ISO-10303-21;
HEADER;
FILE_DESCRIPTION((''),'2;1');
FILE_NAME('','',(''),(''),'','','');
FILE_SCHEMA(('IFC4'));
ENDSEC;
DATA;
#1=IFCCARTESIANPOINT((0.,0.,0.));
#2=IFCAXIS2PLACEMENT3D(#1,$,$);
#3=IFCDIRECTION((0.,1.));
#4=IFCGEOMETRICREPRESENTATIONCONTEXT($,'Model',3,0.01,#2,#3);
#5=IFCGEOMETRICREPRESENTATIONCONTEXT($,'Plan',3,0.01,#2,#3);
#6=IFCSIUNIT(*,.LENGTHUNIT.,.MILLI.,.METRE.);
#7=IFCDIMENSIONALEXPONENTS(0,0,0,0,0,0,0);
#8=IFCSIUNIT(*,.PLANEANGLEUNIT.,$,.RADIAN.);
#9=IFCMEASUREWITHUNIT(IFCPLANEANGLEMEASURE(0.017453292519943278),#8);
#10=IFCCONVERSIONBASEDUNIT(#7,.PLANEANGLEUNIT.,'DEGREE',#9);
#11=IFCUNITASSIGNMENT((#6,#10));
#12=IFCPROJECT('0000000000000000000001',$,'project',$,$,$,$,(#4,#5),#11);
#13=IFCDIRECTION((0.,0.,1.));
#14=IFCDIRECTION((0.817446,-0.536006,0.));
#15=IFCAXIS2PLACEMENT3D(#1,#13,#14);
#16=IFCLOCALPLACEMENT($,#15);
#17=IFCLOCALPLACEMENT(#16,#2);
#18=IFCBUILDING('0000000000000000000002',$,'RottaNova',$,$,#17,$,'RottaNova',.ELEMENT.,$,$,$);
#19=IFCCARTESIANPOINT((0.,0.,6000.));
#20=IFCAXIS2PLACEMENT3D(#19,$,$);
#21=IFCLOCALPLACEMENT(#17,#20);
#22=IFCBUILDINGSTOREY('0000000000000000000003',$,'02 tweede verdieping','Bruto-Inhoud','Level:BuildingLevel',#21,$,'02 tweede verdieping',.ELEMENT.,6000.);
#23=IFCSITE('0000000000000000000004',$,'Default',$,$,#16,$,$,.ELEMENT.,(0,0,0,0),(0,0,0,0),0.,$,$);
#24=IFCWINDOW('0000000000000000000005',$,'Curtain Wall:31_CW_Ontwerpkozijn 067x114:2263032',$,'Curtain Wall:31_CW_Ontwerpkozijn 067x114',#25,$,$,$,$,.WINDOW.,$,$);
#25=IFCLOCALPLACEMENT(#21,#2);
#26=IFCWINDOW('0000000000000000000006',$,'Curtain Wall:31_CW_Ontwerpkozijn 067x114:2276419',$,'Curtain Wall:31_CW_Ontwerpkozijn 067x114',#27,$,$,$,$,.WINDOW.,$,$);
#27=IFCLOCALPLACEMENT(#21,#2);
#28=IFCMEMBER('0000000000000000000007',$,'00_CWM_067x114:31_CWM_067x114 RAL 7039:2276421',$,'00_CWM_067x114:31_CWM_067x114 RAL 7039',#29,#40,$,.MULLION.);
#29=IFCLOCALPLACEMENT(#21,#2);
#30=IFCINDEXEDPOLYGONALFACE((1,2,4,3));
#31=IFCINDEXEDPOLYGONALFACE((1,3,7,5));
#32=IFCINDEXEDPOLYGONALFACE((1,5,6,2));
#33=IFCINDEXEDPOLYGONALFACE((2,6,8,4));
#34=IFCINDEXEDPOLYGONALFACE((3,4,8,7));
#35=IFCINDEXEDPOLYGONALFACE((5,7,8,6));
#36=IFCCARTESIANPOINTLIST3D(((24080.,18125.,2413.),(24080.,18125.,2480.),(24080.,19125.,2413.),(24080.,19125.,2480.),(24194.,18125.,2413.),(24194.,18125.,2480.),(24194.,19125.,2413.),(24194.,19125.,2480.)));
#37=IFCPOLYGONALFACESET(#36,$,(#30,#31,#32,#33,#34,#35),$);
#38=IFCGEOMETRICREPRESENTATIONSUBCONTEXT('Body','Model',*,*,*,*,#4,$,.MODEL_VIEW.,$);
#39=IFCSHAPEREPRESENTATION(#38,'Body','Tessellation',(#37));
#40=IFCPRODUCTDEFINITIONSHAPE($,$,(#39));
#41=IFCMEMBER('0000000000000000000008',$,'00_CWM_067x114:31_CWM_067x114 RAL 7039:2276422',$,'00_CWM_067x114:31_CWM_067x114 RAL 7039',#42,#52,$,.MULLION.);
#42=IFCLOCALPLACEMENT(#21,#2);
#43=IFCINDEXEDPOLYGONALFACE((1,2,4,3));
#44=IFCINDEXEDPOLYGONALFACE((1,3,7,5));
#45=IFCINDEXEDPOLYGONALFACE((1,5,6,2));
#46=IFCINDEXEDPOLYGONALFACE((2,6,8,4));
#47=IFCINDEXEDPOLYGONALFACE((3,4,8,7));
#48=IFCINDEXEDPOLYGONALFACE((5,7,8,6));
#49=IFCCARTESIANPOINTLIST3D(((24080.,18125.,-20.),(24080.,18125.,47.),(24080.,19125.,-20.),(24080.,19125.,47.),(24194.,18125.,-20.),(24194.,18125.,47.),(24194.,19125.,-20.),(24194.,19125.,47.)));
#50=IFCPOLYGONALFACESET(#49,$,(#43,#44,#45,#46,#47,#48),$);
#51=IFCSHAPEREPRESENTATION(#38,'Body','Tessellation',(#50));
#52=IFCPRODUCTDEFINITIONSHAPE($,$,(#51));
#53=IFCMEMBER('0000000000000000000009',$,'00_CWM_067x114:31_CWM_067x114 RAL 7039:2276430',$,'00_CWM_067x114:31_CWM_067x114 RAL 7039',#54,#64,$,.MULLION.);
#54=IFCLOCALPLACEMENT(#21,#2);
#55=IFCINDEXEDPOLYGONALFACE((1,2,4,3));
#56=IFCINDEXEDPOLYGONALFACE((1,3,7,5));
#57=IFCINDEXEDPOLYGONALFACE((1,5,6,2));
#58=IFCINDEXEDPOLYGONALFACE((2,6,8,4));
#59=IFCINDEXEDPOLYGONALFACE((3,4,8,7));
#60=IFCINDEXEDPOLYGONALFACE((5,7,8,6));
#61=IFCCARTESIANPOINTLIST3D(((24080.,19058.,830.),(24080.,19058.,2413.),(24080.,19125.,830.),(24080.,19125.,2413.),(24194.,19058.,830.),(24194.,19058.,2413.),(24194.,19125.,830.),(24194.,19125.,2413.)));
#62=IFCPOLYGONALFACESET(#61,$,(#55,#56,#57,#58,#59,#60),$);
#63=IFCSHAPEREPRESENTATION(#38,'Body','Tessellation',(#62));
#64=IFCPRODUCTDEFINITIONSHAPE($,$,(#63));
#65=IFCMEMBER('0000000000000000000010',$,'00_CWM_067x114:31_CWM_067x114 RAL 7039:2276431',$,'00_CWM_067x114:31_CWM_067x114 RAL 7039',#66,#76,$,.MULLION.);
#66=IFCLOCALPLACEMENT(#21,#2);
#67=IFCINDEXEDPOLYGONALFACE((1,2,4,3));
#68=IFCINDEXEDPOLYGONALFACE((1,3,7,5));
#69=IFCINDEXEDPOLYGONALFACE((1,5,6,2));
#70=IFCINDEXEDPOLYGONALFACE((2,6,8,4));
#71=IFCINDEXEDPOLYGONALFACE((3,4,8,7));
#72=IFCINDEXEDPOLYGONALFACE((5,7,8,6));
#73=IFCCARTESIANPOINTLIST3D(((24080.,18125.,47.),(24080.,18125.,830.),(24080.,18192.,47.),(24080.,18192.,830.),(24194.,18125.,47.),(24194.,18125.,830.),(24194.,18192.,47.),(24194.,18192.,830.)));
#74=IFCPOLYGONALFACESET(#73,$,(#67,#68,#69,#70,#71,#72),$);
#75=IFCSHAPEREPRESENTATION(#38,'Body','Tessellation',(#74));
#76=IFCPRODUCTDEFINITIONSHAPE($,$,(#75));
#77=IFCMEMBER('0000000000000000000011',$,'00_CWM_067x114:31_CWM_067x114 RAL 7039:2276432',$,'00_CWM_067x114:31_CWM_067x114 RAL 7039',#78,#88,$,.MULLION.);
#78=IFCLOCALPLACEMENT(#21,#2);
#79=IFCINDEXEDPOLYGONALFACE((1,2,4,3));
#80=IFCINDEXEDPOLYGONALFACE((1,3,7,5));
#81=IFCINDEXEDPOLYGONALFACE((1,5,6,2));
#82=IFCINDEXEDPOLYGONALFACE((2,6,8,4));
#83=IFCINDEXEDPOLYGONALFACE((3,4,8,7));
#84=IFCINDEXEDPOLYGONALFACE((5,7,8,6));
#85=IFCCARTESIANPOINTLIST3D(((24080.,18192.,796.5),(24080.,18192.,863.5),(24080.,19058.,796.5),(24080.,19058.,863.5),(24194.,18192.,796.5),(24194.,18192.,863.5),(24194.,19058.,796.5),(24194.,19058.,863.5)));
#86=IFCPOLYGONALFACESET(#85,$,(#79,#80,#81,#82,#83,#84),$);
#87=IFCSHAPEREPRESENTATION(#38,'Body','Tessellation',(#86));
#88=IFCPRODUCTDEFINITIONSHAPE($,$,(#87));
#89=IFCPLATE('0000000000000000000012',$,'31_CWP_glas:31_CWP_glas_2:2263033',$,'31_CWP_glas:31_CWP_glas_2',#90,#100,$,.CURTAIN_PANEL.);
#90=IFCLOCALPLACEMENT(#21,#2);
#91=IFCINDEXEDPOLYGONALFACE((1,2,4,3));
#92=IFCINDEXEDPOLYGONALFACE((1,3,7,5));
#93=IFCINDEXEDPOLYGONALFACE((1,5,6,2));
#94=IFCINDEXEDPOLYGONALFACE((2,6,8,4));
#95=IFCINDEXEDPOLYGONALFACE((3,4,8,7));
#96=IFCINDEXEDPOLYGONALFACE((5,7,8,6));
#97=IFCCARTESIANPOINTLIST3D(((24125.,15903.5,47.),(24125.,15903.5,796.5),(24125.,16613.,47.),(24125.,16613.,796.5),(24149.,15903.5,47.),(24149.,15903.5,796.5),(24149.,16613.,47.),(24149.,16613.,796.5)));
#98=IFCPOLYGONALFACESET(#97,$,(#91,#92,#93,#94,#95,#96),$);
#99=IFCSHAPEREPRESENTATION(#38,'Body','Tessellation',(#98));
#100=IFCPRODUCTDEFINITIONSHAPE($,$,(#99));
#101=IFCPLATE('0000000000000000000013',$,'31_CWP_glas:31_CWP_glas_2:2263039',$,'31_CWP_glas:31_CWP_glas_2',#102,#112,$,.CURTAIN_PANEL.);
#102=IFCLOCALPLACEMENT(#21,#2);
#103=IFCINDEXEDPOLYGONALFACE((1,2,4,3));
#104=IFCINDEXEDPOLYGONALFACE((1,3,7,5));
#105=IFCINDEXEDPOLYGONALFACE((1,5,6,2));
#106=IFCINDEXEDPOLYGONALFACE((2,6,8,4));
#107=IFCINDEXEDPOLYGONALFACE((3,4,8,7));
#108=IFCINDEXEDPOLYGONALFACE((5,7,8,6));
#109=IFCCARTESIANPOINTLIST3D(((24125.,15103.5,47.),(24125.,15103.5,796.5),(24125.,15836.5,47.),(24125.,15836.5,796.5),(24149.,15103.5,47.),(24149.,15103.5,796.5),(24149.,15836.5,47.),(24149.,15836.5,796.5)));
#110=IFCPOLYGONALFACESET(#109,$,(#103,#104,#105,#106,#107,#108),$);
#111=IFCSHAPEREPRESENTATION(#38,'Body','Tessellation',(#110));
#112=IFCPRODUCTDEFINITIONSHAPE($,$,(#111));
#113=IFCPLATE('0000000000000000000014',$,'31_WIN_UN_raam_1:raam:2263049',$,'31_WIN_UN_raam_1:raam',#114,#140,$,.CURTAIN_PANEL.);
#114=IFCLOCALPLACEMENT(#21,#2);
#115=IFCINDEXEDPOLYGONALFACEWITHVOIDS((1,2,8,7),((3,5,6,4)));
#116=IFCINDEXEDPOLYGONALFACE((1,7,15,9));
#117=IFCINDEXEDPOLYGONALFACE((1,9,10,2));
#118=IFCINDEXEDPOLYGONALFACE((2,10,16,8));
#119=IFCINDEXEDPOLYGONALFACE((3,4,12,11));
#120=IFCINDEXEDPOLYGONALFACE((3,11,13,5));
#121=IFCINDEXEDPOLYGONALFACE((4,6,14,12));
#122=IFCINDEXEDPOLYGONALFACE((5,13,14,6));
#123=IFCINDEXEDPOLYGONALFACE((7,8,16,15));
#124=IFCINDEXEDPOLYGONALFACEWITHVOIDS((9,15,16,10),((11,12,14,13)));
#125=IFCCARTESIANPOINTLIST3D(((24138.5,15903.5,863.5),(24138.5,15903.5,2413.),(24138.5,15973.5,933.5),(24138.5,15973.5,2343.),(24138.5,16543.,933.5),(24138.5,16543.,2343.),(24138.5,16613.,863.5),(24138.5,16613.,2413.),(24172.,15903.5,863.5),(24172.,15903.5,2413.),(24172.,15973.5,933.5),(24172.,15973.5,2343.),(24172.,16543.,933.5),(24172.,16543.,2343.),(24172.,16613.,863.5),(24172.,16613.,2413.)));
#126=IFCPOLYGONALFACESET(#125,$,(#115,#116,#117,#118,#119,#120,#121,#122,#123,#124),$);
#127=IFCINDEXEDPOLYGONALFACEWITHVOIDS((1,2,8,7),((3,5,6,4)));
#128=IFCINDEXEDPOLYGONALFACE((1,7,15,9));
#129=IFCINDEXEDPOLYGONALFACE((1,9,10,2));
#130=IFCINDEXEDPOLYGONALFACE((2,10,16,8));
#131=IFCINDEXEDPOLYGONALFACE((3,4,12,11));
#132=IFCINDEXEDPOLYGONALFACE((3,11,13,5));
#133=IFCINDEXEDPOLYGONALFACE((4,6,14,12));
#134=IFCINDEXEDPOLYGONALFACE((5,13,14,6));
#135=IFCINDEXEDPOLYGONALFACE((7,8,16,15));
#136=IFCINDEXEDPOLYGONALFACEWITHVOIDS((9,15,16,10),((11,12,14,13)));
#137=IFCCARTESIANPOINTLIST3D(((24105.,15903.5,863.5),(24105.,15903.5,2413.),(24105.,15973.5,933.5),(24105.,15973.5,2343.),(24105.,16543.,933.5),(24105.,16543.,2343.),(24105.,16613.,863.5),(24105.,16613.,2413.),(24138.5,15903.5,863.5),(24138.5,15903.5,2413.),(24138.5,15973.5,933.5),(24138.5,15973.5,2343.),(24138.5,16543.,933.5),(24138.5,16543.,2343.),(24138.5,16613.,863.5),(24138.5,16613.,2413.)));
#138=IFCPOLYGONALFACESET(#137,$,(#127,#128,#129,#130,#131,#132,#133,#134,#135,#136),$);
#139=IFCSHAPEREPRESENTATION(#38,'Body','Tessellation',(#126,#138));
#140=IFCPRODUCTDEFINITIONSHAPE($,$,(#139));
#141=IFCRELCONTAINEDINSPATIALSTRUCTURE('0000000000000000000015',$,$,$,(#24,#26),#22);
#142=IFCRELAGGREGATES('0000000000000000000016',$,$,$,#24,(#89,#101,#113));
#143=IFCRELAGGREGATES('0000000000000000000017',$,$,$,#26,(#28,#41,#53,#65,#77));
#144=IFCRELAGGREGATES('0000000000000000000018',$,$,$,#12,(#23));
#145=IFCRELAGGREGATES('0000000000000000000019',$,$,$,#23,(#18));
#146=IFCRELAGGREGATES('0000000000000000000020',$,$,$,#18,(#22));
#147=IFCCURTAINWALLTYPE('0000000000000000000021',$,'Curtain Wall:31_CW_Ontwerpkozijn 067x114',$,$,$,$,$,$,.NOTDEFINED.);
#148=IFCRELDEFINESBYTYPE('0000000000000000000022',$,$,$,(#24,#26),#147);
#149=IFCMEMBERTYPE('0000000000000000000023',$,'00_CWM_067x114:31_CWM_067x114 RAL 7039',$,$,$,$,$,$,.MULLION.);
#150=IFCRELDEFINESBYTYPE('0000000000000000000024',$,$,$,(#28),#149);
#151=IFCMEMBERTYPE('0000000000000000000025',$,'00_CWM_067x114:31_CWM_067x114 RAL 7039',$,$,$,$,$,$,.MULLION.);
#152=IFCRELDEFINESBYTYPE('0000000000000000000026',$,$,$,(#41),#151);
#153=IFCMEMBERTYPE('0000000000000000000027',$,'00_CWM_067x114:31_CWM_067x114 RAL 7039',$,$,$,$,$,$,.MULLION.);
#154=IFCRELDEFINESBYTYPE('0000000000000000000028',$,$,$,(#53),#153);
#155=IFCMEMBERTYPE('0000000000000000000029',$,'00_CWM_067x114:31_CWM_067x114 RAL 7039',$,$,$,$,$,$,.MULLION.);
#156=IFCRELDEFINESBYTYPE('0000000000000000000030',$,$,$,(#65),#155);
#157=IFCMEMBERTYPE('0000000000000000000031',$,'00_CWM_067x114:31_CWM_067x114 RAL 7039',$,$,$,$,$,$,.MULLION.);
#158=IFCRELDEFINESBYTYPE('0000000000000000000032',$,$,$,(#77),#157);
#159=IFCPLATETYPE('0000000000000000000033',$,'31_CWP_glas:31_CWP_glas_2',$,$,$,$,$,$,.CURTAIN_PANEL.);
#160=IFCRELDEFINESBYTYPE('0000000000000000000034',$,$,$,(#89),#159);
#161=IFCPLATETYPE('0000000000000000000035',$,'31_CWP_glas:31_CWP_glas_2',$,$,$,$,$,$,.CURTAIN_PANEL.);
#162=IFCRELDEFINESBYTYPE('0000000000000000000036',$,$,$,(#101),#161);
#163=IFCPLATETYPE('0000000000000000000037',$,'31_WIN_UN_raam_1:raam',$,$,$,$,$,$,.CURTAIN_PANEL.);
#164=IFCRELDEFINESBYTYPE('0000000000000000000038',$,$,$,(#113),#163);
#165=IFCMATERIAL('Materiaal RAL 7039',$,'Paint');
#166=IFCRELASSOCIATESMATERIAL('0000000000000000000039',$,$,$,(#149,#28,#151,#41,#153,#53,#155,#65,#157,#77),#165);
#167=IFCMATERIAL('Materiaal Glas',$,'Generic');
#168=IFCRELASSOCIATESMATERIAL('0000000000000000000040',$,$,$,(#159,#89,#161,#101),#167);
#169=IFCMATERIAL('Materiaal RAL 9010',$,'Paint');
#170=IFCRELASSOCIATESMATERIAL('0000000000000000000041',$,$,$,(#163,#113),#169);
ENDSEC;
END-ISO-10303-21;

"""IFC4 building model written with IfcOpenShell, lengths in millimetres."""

from ifc_helpers import new_model, entity, si_unit, converted_unit, direction, frame, origin, place, context, subcontext, project, spatial, indexed_curve, outline, extrude, source, transform, mapped, material, type_object, type_shapes, element, aggregate, save


model = new_model("IFC4")

# Units and contexts
model_context = context("Model", 3, precision=0.01, world=origin(), true_north=direction((0.0, 1.0)))
plan_context = context("Plan", 3, precision=0.01, world=origin(), true_north=direction((0.0, 1.0)))
body_context = subcontext(model_context, "Body", "Model", "MODEL_VIEW")
ifc_project = project(units=[si_unit("LENGTHUNIT", "METRE", prefix="MILLI"), converted_unit("PLANEANGLEUNIT", "DEGREE", entity("IfcPlaneAngleMeasure", 0.017453292519943278), si_unit("PLANEANGLEUNIT", "RADIAN"), dimensions=[0, 0, 0, 0, 0, 0, 0])], contexts=[model_context, plan_context])

# Site, building, storey
site_placement = place(None, frame((0.0, 0.0, 0.0), z_axis=(0.0, 0.0, 1.0), x_axis=(0.817446, -0.536006, 0.0)))
site = spatial("IfcSite", under=ifc_project, at=site_placement, Name="Default", CompositionType="ELEMENT", RefLatitude=(0, 0, 0, 0), RefLongitude=(0, 0, 0, 0), RefElevation=0.0)
building_placement = place(site_placement, origin())
building = spatial("IfcBuilding", under=site, at=building_placement, Name="RottaNova", LongName="RottaNova", CompositionType="ELEMENT")
storey_placement = place(building_placement, frame((0.0, 0.0, 6000.0)))
storey = spatial("IfcBuildingStorey", under=building, at=storey_placement, Name="02 tweede verdieping", Description="Bruto-Inhoud", ObjectType="Level:BuildingLevel", LongName="02 tweede verdieping", CompositionType="ELEMENT", Elevation=6000.0)

# Windows, members
curtain_wall_type = type_object("IfcCurtainWallType", Name="Curtain Wall:31_CW_Ontwerpkozijn 067x114", PredefinedType="NOTDEFINED")
window_1_placement = place(storey_placement, frame((0.0, 0.0, -6000.0)))
window_1 = element("IfcWindow", 1, at=window_1_placement, inside=storey, type_object=curtain_wall_type, Name="Curtain Wall:31_CW_Ontwerpkozijn 067x114:2263032", ObjectType="Curtain Wall:31_CW_Ontwerpkozijn 067x114", PredefinedType="WINDOW")
ifc_material_1 = material(Name="Materiaal RAL 7039", Category="Paint")
window_2_placement = place(storey_placement, frame((0.0, 0.0, -6000.0)))
window_2 = element("IfcWindow", 2, at=window_2_placement, inside=storey, type_object=curtain_wall_type, Name="Curtain Wall:31_CW_Ontwerpkozijn 067x114:2276419", ObjectType="Curtain Wall:31_CW_Ontwerpkozijn 067x114", PredefinedType="WINDOW")
member_type_1 = type_object("IfcMemberType", Name="00_CWM_067x114:31_CWM_067x114 RAL 7039", PredefinedType="MULLION", material=ifc_material_1)
shared_shape_1 = source(origin(), body_context, "Body", "SweptSolid", [
    extrude(outline(indexed_curve([(-33.5, -57.0), (33.5, -57.0), (33.5, 57.0), (-33.5, 57.0), (-33.5, -57.0)], self_intersect=False)), frame((-33.5, 57.0, -1000.0), z_axis=(0.0, 0.0, 1.0), x_axis=(-1.0, 0.0, 0.0)), (0.0, 0.0, 1.0), 1000.0),
])
type_shapes(member_type_1, [shared_shape_1])
member_1_placement = place(window_2_placement, frame((24080.0, 19125.0, 8480.0), z_axis=(0.0, 1.0, 0.0), x_axis=(0.0, 0.0, 1.0)))
member_1 = element("IfcMember", 3, at=member_1_placement, type_object=member_type_1, material=ifc_material_1, Name="00_CWM_067x114:31_CWM_067x114 RAL 7039:2276421", ObjectType="00_CWM_067x114:31_CWM_067x114 RAL 7039", PredefinedType="MULLION", context=body_context, shape_type="MappedRepresentation", body=[
    mapped(shared_shape_1, transform((0.0, 0.0, 0.0), scale=1.0)),
])
member_type_2 = type_object("IfcMemberType", Name="00_CWM_067x114:31_CWM_067x114 RAL 7039", PredefinedType="MULLION", material=ifc_material_1)
shared_shape_2 = source(origin(), body_context, "Body", "SweptSolid", [
    extrude(outline(indexed_curve([(-33.5, -57.0), (33.5, -57.0), (33.5, 57.0), (-33.5, 57.0), (-33.5, -57.0)], self_intersect=False)), frame((-33.5, 57.0, -1000.0), z_axis=(0.0, 0.0, 1.0), x_axis=(-1.0, 0.0, 0.0)), (0.0, 0.0, 1.0), 1000.0),
])
type_shapes(member_type_2, [shared_shape_2])
member_2_placement = place(window_2_placement, frame((24080.0, 18125.0, 5980.0), z_axis=(0.0, -1.0, 0.0), x_axis=(0.0, 0.0, -1.0)))
member_2 = element("IfcMember", 4, at=member_2_placement, type_object=member_type_2, material=ifc_material_1, Name="00_CWM_067x114:31_CWM_067x114 RAL 7039:2276422", ObjectType="00_CWM_067x114:31_CWM_067x114 RAL 7039", PredefinedType="MULLION", context=body_context, shape_type="MappedRepresentation", body=[
    mapped(shared_shape_2, transform((0.0, 0.0, 0.0), scale=1.0)),
])
member_type_3 = type_object("IfcMemberType", Name="00_CWM_067x114:31_CWM_067x114 RAL 7039", PredefinedType="MULLION", material=ifc_material_1)
shared_shape_3 = source(origin(), body_context, "Body", "SweptSolid", [
    extrude(outline(indexed_curve([(-33.5, -57.0), (33.5, -57.0), (33.5, 57.0), (-33.5, 57.0), (-33.5, -57.0)], self_intersect=False)), frame((-33.5, 57.0, -1583.0), z_axis=(0.0, 0.0, 1.0), x_axis=(-1.0, 0.0, 0.0)), (0.0, 0.0, 1.0), 1583.0),
])
type_shapes(member_type_3, [shared_shape_3])
member_3_placement = place(window_2_placement, frame((24080.0, 19125.0, 6830.0), z_axis=(0.0, 0.0, -1.0), x_axis=(0.0, 1.0, 0.0)))
member_3 = element("IfcMember", 5, at=member_3_placement, type_object=member_type_3, material=ifc_material_1, Name="00_CWM_067x114:31_CWM_067x114 RAL 7039:2276430", ObjectType="00_CWM_067x114:31_CWM_067x114 RAL 7039", PredefinedType="MULLION", context=body_context, shape_type="MappedRepresentation", body=[
    mapped(shared_shape_3, transform((0.0, 0.0, 0.0), scale=1.0)),
])
member_type_4 = type_object("IfcMemberType", Name="00_CWM_067x114:31_CWM_067x114 RAL 7039", PredefinedType="MULLION", material=ifc_material_1)
shared_shape_4 = source(origin(), body_context, "Body", "SweptSolid", [
    extrude(outline(indexed_curve([(-33.5, -57.0), (33.5, -57.0), (33.5, 57.0), (-33.5, 57.0), (-33.5, -57.0)], self_intersect=False)), frame((-33.5, 57.0, -783.0), z_axis=(0.0, 0.0, 1.0), x_axis=(-1.0, 0.0, 0.0)), (0.0, 0.0, 1.0), 783.0),
])
type_shapes(member_type_4, [shared_shape_4])
member_4_placement = place(window_2_placement, frame((24080.0, 18125.0, 6830.0), z_axis=(0.0, 0.0, 1.0), x_axis=(0.0, -1.0, 0.0)))
member_4 = element("IfcMember", 6, at=member_4_placement, type_object=member_type_4, material=ifc_material_1, Name="00_CWM_067x114:31_CWM_067x114 RAL 7039:2276431", ObjectType="00_CWM_067x114:31_CWM_067x114 RAL 7039", PredefinedType="MULLION", context=body_context, shape_type="MappedRepresentation", body=[
    mapped(shared_shape_4, transform((0.0, 0.0, 0.0), scale=1.0)),
])
member_type_5 = type_object("IfcMemberType", Name="00_CWM_067x114:31_CWM_067x114 RAL 7039", PredefinedType="MULLION", material=ifc_material_1)
shared_shape_5 = source(origin(), body_context, "Body", "SweptSolid", [
    extrude(outline(indexed_curve([(-33.5, -57.0), (33.5, -57.0), (33.5, 57.0), (-33.5, 57.0), (-33.5, -57.0)], self_intersect=False)), frame((0.0, 57.0, -866.0), z_axis=(0.0, 0.0, 1.0), x_axis=(-1.0, 0.0, 0.0)), (0.0, 0.0, 1.0), 866.0),
])
type_shapes(member_type_5, [shared_shape_5])
member_5_placement = place(window_2_placement, frame((24080.0, 19058.0, 6830.0), z_axis=(0.0, 1.0, 0.0), x_axis=(0.0, 0.0, 1.0)))
member_5 = element("IfcMember", 7, at=member_5_placement, type_object=member_type_5, material=ifc_material_1, Name="00_CWM_067x114:31_CWM_067x114 RAL 7039:2276432", ObjectType="00_CWM_067x114:31_CWM_067x114 RAL 7039", PredefinedType="MULLION", context=body_context, shape_type="MappedRepresentation", body=[
    mapped(shared_shape_5, transform((0.0, 0.0, 0.0), scale=1.0)),
])

# Plates
ifc_material_2 = material(Name="Materiaal Glas", Category="Generic")
plate_type_1 = type_object("IfcPlateType", Name="31_CWP_glas:31_CWP_glas_2", PredefinedType="CURTAIN_PANEL", material=ifc_material_2)
shared_shape_6 = source(origin(), body_context, "Body", "SweptSolid", [
    extrude(outline(indexed_curve([(-12.0, -354.8), (12.0, -354.8), (12.0, 354.8), (-12.0, 354.8), (-12.0, -354.8)], self_intersect=False)), frame((0.0, 57.0, 0.0), z_axis=(0.0, 0.0, 1.0), x_axis=(0.0, 1.0, 0.0)), (0.0, 0.0, 1.0), 749.5),
])
type_shapes(plate_type_1, [shared_shape_6])
plate_1_placement = place(window_1_placement, frame((24080.0, 16258.3, 6047.0), z_axis=(0.0, 0.0, 1.0), x_axis=(0.0, -1.0, 0.0)))
plate_1 = element("IfcPlate", 8, at=plate_1_placement, type_object=plate_type_1, material=ifc_material_2, Name="31_CWP_glas:31_CWP_glas_2:2263033", ObjectType="31_CWP_glas:31_CWP_glas_2", PredefinedType="CURTAIN_PANEL", context=body_context, shape_type="MappedRepresentation", body=[
    mapped(shared_shape_6, transform((0.0, 0.0, 0.0), scale=1.0)),
])
plate_type_2 = type_object("IfcPlateType", Name="31_CWP_glas:31_CWP_glas_2", PredefinedType="CURTAIN_PANEL", material=ifc_material_2)
shared_shape_7 = source(origin(), body_context, "Body", "SweptSolid", [
    extrude(outline(indexed_curve([(-12.0, -366.5), (12.0, -366.5), (12.0, 366.5), (-12.0, 366.5), (-12.0, -366.5)], self_intersect=False)), frame((0.0, 57.0, 0.0), z_axis=(0.0, 0.0, 1.0), x_axis=(0.0, 1.0, 0.0)), (0.0, 0.0, 1.0), 749.5),
])
type_shapes(plate_type_2, [shared_shape_7])
plate_2_placement = place(window_1_placement, frame((24080.0, 15470.0, 6047.0), z_axis=(0.0, 0.0, 1.0), x_axis=(0.0, -1.0, 0.0)))
plate_2 = element("IfcPlate", 9, at=plate_2_placement, type_object=plate_type_2, material=ifc_material_2, Name="31_CWP_glas:31_CWP_glas_2:2263039", ObjectType="31_CWP_glas:31_CWP_glas_2", PredefinedType="CURTAIN_PANEL", context=body_context, shape_type="MappedRepresentation", body=[
    mapped(shared_shape_7, transform((0.0, 0.0, 0.0), scale=1.0)),
])
ifc_material_3 = material(Name="Materiaal RAL 9010", Category="Paint")
plate_type_3 = type_object("IfcPlateType", Name="31_WIN_UN_raam_1:raam", PredefinedType="CURTAIN_PANEL", material=ifc_material_3)
shared_shape_8 = source(origin(), body_context, "Body", "SweptSolid", [
    extrude(outline(indexed_curve([(-354.7, -774.7), (354.7, -774.7), (354.7, 774.7), (-354.7, 774.7), (-354.7, -774.7)], self_intersect=False), holes=[indexed_curve([(-284.7, 704.7), (284.7, 704.7), (284.7, -704.8), (-284.7, -704.8), (-284.7, 704.7)], self_intersect=False)]), frame((0.0, 58.5, 774.8), z_axis=(0.0, 1.0, 0.0), x_axis=(1.0, 0.0, 0.0)), (0.0, 0.0, 1.0), 33.5),
    extrude(outline(indexed_curve([(-354.7, -774.7), (354.7, -774.7), (354.7, 774.7), (-354.7, 774.7), (-354.7, -774.7)], self_intersect=False), holes=[indexed_curve([(-284.7, 704.7), (284.7, 704.7), (284.7, -704.8), (-284.7, -704.8), (-284.7, 704.7)], self_intersect=False)]), frame((0.0, 25.0, 774.8), z_axis=(0.0, 1.0, 0.0), x_axis=(1.0, 0.0, 0.0)), (0.0, 0.0, 1.0), 33.5),
])
type_shapes(plate_type_3, [shared_shape_8])
plate_3_placement = place(window_1_placement, frame((24080.0, 16258.3, 6863.5), z_axis=(0.0, 0.0, 1.0), x_axis=(0.0, -1.0, 0.0)))
plate_3 = element("IfcPlate", 10, at=plate_3_placement, type_object=plate_type_3, material=ifc_material_3, Name="31_WIN_UN_raam_1:raam:2263049", ObjectType="31_WIN_UN_raam_1:raam", PredefinedType="CURTAIN_PANEL", context=body_context, shape_type="MappedRepresentation", body=[
    mapped(shared_shape_8, transform((0.0, 0.0, 0.0), scale=1.0)),
])
aggregate(window_1, [plate_1, plate_2, plate_3])
aggregate(window_2, [member_1, member_2, member_3, member_4, member_5])

save(model, "model.ifc")
